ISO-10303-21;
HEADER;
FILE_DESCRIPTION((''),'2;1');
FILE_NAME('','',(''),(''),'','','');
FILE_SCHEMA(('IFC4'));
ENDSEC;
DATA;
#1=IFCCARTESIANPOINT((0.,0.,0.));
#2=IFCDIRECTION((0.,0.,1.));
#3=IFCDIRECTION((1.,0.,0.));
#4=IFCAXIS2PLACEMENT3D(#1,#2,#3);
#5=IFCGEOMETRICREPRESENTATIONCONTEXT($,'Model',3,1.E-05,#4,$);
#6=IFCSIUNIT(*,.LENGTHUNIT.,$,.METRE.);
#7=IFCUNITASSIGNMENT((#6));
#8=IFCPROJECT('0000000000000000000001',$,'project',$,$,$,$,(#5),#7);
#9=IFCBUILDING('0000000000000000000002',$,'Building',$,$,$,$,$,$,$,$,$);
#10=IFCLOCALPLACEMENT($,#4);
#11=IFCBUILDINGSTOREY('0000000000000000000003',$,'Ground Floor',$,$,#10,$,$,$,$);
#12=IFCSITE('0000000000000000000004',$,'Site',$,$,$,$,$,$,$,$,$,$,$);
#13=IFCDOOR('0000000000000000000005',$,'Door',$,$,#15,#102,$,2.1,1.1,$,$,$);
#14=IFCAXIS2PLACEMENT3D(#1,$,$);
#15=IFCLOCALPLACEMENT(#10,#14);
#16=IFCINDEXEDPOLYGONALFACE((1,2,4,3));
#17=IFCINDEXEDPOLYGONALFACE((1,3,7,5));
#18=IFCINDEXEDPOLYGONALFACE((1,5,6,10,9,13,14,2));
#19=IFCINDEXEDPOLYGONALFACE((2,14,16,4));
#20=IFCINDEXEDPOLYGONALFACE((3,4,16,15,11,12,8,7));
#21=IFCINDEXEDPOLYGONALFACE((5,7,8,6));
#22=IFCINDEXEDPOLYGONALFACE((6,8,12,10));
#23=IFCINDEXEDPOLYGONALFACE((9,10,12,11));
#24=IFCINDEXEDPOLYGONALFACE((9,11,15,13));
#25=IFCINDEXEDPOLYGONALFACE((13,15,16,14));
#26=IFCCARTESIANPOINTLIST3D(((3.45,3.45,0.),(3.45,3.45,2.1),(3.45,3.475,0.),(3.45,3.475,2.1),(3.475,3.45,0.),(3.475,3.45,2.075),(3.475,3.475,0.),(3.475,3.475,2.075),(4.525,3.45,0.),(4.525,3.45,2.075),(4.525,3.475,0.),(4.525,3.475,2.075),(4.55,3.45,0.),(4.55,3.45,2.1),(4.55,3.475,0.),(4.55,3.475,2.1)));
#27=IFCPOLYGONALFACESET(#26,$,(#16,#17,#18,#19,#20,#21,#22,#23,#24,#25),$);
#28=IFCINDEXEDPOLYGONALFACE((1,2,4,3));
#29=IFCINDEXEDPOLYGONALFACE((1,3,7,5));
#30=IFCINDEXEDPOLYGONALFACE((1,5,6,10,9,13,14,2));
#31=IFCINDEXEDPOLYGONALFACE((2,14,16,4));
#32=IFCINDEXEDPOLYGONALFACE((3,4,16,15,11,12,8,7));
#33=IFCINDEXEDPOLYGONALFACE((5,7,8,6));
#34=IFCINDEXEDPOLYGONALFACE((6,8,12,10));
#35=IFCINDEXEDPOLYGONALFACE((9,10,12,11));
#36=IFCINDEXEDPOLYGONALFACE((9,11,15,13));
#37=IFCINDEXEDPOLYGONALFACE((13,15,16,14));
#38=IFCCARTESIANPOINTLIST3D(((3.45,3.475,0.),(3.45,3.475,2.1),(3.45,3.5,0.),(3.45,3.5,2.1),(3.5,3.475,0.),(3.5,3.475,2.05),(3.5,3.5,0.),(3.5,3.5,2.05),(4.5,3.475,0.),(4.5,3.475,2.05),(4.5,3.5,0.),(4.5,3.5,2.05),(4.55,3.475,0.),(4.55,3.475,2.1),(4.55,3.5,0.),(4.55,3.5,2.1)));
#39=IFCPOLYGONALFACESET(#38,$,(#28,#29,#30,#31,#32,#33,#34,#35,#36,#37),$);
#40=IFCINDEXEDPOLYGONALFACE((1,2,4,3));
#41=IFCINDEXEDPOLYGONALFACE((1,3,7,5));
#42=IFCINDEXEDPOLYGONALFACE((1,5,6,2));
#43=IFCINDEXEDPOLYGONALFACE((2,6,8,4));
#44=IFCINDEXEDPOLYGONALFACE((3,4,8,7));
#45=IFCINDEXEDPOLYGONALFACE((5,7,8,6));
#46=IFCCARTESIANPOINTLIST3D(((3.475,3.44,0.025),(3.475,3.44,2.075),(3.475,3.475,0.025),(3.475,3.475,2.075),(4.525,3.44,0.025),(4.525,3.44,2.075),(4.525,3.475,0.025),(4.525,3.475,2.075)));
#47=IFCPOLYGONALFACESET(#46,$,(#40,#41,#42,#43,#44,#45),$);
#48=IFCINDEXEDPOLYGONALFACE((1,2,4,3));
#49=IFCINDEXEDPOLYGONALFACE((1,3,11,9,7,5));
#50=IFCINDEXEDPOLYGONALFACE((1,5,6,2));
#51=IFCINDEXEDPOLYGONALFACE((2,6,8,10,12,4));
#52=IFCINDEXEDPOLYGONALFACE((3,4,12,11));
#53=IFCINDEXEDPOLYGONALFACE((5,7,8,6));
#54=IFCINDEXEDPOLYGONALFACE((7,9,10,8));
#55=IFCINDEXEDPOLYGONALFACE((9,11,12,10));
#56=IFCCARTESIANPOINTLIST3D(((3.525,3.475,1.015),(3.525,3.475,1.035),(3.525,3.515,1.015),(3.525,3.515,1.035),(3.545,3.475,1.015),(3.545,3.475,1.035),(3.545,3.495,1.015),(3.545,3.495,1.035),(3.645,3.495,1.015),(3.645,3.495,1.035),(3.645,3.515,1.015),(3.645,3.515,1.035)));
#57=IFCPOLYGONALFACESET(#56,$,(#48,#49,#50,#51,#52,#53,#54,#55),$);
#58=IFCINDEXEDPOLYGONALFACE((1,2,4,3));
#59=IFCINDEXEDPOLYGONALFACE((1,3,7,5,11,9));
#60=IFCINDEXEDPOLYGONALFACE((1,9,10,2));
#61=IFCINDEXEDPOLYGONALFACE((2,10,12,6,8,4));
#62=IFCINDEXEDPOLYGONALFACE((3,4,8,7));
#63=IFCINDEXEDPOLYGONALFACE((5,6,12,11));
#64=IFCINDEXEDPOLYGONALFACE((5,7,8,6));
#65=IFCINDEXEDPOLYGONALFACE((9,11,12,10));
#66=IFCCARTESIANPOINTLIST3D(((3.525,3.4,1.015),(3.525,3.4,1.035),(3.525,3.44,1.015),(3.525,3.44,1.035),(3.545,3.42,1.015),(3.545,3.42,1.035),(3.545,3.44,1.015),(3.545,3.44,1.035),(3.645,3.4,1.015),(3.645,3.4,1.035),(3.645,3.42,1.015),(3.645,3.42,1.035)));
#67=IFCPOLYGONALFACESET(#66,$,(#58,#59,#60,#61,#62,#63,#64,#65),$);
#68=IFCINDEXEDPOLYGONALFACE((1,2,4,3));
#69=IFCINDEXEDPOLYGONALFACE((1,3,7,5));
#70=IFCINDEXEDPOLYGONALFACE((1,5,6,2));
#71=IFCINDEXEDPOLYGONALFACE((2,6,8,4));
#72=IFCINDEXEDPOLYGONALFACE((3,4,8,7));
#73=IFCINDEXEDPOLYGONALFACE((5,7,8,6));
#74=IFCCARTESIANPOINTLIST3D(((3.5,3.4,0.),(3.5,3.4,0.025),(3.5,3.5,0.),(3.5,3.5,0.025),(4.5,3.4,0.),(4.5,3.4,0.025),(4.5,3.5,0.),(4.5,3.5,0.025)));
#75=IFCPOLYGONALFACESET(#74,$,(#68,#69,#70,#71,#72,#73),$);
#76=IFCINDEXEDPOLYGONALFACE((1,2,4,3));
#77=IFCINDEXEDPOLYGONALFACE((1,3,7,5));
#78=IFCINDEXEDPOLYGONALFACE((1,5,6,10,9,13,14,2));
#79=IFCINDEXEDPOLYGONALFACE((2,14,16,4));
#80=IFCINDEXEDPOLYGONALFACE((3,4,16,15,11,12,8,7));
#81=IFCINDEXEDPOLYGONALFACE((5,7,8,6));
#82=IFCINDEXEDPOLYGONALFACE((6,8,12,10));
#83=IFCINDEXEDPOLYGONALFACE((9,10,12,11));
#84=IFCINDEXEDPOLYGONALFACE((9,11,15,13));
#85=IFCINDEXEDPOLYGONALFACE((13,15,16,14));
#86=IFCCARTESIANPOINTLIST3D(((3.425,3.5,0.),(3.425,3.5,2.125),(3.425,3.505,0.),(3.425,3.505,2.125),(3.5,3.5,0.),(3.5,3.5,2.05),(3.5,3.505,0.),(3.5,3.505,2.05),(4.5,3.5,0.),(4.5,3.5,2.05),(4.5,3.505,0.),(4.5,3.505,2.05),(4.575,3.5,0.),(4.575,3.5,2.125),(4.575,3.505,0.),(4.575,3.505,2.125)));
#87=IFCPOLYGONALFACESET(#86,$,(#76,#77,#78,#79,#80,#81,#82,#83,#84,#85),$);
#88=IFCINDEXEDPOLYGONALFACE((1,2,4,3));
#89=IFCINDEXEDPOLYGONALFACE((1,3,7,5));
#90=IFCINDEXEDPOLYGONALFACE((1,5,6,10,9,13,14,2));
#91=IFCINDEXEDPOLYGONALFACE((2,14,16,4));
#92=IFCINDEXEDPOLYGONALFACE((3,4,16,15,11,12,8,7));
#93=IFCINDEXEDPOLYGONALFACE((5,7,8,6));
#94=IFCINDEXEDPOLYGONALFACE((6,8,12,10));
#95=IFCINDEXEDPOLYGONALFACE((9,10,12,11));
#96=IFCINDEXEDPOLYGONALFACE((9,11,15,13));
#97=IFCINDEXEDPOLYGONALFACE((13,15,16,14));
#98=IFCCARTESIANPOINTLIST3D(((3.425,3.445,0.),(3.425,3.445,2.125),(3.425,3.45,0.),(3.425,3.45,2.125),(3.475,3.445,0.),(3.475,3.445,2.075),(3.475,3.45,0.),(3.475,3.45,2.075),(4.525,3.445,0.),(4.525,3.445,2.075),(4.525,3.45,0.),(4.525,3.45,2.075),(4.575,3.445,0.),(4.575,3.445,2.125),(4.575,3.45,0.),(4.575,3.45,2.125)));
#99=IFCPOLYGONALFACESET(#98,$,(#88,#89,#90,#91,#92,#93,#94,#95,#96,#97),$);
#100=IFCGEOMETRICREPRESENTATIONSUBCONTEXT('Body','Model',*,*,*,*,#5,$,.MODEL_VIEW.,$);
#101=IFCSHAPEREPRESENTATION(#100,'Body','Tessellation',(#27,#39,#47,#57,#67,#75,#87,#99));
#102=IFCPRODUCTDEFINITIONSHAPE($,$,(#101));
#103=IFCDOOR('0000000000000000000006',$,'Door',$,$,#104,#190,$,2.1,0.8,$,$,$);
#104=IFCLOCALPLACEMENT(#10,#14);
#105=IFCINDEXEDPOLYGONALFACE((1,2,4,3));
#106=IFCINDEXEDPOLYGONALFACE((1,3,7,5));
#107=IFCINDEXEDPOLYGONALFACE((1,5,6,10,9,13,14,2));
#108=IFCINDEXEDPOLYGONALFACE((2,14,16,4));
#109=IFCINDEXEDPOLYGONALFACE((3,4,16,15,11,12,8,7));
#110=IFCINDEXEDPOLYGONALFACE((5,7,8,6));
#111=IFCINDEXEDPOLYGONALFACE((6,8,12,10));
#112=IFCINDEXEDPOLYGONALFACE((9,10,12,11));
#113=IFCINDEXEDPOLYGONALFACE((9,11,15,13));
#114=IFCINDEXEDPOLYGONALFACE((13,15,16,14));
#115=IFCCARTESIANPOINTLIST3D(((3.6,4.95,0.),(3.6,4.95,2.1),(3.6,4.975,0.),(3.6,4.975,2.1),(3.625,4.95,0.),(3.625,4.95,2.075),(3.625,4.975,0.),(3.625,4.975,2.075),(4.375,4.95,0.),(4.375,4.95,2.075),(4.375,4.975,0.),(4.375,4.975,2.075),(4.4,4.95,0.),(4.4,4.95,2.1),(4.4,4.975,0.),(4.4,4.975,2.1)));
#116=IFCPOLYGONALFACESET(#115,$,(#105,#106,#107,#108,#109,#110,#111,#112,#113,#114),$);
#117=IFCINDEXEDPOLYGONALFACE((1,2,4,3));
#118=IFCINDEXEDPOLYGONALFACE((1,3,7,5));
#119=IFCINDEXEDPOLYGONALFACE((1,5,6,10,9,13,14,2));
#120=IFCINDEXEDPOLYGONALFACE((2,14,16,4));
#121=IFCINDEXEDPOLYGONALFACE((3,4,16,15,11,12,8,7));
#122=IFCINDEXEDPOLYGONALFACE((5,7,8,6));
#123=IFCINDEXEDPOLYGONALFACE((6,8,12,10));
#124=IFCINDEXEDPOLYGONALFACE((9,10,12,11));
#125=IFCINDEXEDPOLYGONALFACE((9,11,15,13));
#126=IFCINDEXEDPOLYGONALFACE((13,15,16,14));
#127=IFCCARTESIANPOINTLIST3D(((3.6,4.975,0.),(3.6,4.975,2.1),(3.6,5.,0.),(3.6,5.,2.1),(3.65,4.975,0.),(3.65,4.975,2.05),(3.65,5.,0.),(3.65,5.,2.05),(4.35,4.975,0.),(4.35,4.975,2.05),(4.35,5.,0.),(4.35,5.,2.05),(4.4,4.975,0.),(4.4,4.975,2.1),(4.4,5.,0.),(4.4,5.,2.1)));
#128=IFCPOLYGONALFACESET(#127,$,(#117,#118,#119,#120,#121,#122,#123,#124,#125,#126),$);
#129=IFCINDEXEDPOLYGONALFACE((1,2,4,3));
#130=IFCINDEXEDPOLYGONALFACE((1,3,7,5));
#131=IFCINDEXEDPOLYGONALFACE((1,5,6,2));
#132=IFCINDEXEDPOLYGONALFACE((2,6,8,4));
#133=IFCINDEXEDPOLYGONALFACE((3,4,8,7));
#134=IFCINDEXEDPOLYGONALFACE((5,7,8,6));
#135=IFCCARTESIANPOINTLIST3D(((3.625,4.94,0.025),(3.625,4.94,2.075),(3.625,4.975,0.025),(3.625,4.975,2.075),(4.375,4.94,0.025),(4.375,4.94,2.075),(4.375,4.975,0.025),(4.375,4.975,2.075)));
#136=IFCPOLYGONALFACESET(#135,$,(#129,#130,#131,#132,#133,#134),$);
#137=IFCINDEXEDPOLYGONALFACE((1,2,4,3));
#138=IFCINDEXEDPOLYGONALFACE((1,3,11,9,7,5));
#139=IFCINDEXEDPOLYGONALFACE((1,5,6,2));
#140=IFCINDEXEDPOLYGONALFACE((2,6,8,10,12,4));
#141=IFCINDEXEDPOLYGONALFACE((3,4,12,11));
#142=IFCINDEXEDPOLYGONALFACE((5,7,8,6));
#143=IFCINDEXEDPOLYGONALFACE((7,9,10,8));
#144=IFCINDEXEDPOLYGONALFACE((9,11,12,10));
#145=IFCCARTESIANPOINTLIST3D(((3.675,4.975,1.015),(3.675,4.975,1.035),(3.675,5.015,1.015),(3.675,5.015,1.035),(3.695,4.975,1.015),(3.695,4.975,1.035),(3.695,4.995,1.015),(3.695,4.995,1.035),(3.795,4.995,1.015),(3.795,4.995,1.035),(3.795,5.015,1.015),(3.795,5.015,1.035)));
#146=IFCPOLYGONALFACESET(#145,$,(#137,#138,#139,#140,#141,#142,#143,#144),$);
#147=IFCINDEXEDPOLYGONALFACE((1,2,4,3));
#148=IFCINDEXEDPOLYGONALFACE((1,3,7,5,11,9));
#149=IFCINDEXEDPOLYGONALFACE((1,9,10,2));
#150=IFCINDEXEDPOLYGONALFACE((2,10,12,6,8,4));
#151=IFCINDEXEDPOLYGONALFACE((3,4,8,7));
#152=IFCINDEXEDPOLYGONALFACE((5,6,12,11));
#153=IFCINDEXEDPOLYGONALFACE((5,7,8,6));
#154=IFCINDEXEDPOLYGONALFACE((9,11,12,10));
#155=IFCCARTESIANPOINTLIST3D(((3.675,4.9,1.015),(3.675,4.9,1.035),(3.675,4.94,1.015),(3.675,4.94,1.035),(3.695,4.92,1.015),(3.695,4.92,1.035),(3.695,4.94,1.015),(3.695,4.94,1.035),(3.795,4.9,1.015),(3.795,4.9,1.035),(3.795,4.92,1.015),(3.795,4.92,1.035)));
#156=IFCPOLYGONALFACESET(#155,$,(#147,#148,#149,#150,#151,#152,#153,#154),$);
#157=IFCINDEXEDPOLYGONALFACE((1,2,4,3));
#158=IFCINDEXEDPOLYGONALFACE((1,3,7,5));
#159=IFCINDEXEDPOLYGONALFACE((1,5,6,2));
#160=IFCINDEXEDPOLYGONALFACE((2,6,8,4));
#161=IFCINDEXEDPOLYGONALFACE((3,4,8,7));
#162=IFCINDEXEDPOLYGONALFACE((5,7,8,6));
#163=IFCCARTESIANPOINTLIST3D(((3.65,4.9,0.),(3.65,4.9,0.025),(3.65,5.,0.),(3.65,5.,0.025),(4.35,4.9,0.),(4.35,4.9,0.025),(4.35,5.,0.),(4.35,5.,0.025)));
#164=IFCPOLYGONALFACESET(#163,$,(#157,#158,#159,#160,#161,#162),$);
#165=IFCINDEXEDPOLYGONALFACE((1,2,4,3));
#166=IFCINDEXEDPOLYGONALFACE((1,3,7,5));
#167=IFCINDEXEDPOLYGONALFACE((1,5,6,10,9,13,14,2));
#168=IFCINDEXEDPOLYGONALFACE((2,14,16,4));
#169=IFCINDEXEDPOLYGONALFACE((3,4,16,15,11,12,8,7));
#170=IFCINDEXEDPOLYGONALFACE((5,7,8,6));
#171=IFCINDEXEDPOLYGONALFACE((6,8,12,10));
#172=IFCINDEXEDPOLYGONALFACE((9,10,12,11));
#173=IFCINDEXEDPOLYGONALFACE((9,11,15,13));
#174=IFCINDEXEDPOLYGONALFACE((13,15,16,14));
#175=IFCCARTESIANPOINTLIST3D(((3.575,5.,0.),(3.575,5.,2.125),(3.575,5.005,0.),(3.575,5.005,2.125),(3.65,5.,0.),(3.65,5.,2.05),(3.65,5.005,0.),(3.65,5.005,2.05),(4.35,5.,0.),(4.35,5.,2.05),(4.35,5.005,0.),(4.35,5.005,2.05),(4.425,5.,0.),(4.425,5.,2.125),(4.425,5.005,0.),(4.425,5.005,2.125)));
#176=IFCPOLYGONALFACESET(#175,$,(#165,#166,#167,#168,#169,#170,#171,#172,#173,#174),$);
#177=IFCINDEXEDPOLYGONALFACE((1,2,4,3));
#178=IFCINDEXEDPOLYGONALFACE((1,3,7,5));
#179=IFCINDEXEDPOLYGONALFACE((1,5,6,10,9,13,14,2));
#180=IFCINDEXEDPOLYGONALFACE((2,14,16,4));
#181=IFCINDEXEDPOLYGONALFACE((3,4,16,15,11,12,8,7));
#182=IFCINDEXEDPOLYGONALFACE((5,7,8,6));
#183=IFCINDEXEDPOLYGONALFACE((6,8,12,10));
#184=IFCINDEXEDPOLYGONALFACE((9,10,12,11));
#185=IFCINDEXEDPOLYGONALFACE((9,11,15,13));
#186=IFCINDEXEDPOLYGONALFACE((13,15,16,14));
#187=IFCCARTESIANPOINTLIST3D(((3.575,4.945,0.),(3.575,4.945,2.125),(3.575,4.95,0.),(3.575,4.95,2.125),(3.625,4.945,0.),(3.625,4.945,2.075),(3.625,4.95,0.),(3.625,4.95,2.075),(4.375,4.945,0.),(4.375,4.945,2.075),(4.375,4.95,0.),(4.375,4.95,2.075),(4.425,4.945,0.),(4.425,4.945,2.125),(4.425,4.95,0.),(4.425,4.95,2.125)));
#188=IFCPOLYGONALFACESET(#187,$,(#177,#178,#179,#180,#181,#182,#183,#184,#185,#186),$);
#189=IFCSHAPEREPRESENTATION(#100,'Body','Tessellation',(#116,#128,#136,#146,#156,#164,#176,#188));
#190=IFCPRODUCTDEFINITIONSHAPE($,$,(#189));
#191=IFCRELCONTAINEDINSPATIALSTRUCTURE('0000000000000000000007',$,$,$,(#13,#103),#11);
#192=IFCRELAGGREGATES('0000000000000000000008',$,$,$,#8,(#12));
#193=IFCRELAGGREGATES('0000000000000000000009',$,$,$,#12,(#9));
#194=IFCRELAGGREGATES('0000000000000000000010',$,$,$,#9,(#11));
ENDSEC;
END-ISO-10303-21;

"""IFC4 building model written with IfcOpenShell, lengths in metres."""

from ifc_helpers import new_model, si_unit, frame, origin_with_axes, place, context, subcontext, project, spatial, line, indexed_curve, outline, extrude, element, save


model = new_model("IFC4")

# Units and contexts
model_context = context("Model", 3, precision=1e-05, world=origin_with_axes())
body_context = subcontext(model_context, "Body", "Model", "MODEL_VIEW")
ifc_project = project(units=[si_unit("LENGTHUNIT", "METRE")], contexts=[model_context])

# Site, building, storey
site = spatial("IfcSite", under=ifc_project, Name="Site")
building = spatial("IfcBuilding", under=site, Name="Building")
storey_placement = place(None, origin_with_axes())
storey = spatial("IfcBuildingStorey", under=building, at=storey_placement, Name="Ground Floor")

# Doors
door_1_placement = place(storey_placement, frame((4.55, 3.5, 0.0), z_axis=(0.0, 0.0, 1.0), x_axis=(-1.0, 0.0, 0.0)))
element("IfcDoor", 1, at=door_1_placement, inside=storey, Name="Door", OverallHeight=2.1, OverallWidth=1.1, context=body_context, shape_type="SweptSolid", body=[
    extrude(outline(indexed_curve([(0.0, 0.0), (0.0, 2.1), (1.1, 2.1), (1.1, 0.0), (1.075, 0.0), (1.075, 2.075), (0.025, 2.075), (0.025, 0.0)], segments=[line(1, 2, 3, 4, 5, 6, 7, 8, 1)])), frame((0.0, 0.025, 0.0), z_axis=(0.0, -1.0, 0.0), x_axis=(1.0, 0.0, 0.0)), (0.0, 0.0, -1.0), 0.025),
    extrude(outline(indexed_curve([(0.0, 0.0), (0.0, 2.1), (1.1, 2.1), (1.1, 0.0), (1.05, 0.0), (1.05, 2.05), (0.05, 2.05), (0.05, 0.0)], segments=[line(1, 2, 3, 4, 5, 6, 7, 8, 1)])), frame((0.0, 0.0, 0.0), z_axis=(0.0, -1.0, 0.0), x_axis=(1.0, 0.0, 0.0)), (0.0, 0.0, -1.0), 0.025),
    extrude(outline(indexed_curve([(0.0, 0.0), (1.05, 0.0), (1.05, 0.035), (0.0, 0.035)], segments=[line(1, 2, 3, 4, 1)])), frame((0.025, 0.025, 0.025), z_axis=(0.0, 0.0, 1.0), x_axis=(1.0, 0.0, 0.0)), (0.0, 0.0, 1.0), 2.05),
    extrude(outline(indexed_curve([(0.0, 0.0), (0.0, -0.04), (-0.12, -0.04), (-0.12, -0.02), (-0.02, -0.02), (-0.02, 0.0)], segments=[line(1, 2, 3, 4, 5, 6, 1)])), frame((1.025, 0.025, 1.015), z_axis=(0.0, 0.0, 1.0), x_axis=(1.0, 0.0, 0.0)), (0.0, 0.0, 1.0), 0.02),
    extrude(outline(indexed_curve([(0.0, 0.0), (0.0, 0.04), (-0.12, 0.04), (-0.12, 0.02), (-0.02, 0.02), (-0.02, 0.0)], segments=[line(1, 2, 3, 4, 5, 6, 1)])), frame((1.025, 0.06, 1.015), z_axis=(0.0, 0.0, 1.0), x_axis=(1.0, 0.0, 0.0)), (0.0, 0.0, 1.0), 0.02),
    extrude(outline(indexed_curve([(0.0, 0.0), (1.0, 0.0), (1.0, 0.1), (0.0, 0.1)], segments=[line(1, 2, 3, 4, 1)])), frame((0.05, 0.0, 0.0), z_axis=(0.0, 0.0, 1.0), x_axis=(1.0, 0.0, 0.0)), (0.0, 0.0, 1.0), 0.025),
    extrude(outline(indexed_curve([(0.0, 0.0), (0.0, 2.125), (1.15, 2.125), (1.15, 0.0), (1.075, 0.0), (1.075, 2.05), (0.075, 2.05), (0.075, 0.0)], segments=[line(1, 2, 3, 4, 5, 6, 7, 8, 1)])), frame((-0.025, -0.005, 0.0), z_axis=(0.0, -1.0, 0.0), x_axis=(1.0, 0.0, 0.0)), (0.0, 0.0, -1.0), 0.005),
    extrude(outline(indexed_curve([(0.0, 0.0), (0.0, 2.125), (1.15, 2.125), (1.15, 0.0), (1.1, 0.0), (1.1, 2.075), (0.05, 2.075), (0.05, 0.0)], segments=[line(1, 2, 3, 4, 5, 6, 7, 8, 1)])), frame((-0.025, 0.05, 0.0), z_axis=(0.0, -1.0, 0.0), x_axis=(1.0, 0.0, 0.0)), (0.0, 0.0, -1.0), 0.005),
])
door_2_placement = place(storey_placement, frame((4.4, 5.0, 0.0), z_axis=(0.0, 0.0, 1.0), x_axis=(-1.0, 0.0, 0.0)))
element("IfcDoor", 2, at=door_2_placement, inside=storey, Name="Door", OverallHeight=2.1, OverallWidth=0.8, context=body_context, shape_type="SweptSolid", body=[
    extrude(outline(indexed_curve([(0.0, 0.0), (0.0, 2.1), (0.8, 2.1), (0.8, 0.0), (0.775, 0.0), (0.775, 2.075), (0.025, 2.075), (0.025, 0.0)], segments=[line(1, 2, 3, 4, 5, 6, 7, 8, 1)])), frame((0.0, 0.025, 0.0), z_axis=(0.0, -1.0, 0.0), x_axis=(1.0, 0.0, 0.0)), (0.0, 0.0, -1.0), 0.025),
    extrude(outline(indexed_curve([(0.0, 0.0), (0.0, 2.1), (0.8, 2.1), (0.8, 0.0), (0.75, 0.0), (0.75, 2.05), (0.05, 2.05), (0.05, 0.0)], segments=[line(1, 2, 3, 4, 5, 6, 7, 8, 1)])), frame((0.0, 0.0, 0.0), z_axis=(0.0, -1.0, 0.0), x_axis=(1.0, 0.0, 0.0)), (0.0, 0.0, -1.0), 0.025),
    extrude(outline(indexed_curve([(0.0, 0.0), (0.75, 0.0), (0.75, 0.035), (0.0, 0.035)], segments=[line(1, 2, 3, 4, 1)])), frame((0.025, 0.025, 0.025), z_axis=(0.0, 0.0, 1.0), x_axis=(1.0, 0.0, 0.0)), (0.0, 0.0, 1.0), 2.05),
    extrude(outline(indexed_curve([(0.0, 0.0), (0.0, -0.04), (-0.12, -0.04), (-0.12, -0.02), (-0.02, -0.02), (-0.02, 0.0)], segments=[line(1, 2, 3, 4, 5, 6, 1)])), frame((0.725, 0.025, 1.015), z_axis=(0.0, 0.0, 1.0), x_axis=(1.0, 0.0, 0.0)), (0.0, 0.0, 1.0), 0.02),
    extrude(outline(indexed_curve([(0.0, 0.0), (0.0, 0.04), (-0.12, 0.04), (-0.12, 0.02), (-0.02, 0.02), (-0.02, 0.0)], segments=[line(1, 2, 3, 4, 5, 6, 1)])), frame((0.725, 0.06, 1.015), z_axis=(0.0, 0.0, 1.0), x_axis=(1.0, 0.0, 0.0)), (0.0, 0.0, 1.0), 0.02),
    extrude(outline(indexed_curve([(0.0, 0.0), (0.7, 0.0), (0.7, 0.1), (0.0, 0.1)], segments=[line(1, 2, 3, 4, 1)])), frame((0.05, 0.0, 0.0), z_axis=(0.0, 0.0, 1.0), x_axis=(1.0, 0.0, 0.0)), (0.0, 0.0, 1.0), 0.025),
    extrude(outline(indexed_curve([(0.0, 0.0), (0.0, 2.125), (0.85, 2.125), (0.85, 0.0), (0.775, 0.0), (0.775, 2.05), (0.075, 2.05), (0.075, 0.0)], segments=[line(1, 2, 3, 4, 5, 6, 7, 8, 1)])), frame((-0.025, -0.005, 0.0), z_axis=(0.0, -1.0, 0.0), x_axis=(1.0, 0.0, 0.0)), (0.0, 0.0, -1.0), 0.005),
    extrude(outline(indexed_curve([(0.0, 0.0), (0.0, 2.125), (0.85, 2.125), (0.85, 0.0), (0.8, 0.0), (0.8, 2.075), (0.05, 2.075), (0.05, 0.0)], segments=[line(1, 2, 3, 4, 5, 6, 7, 8, 1)])), frame((-0.025, 0.05, 0.0), z_axis=(0.0, -1.0, 0.0), x_axis=(1.0, 0.0, 0.0)), (0.0, 0.0, -1.0), 0.005),
])

save(model, "model.ifc")
